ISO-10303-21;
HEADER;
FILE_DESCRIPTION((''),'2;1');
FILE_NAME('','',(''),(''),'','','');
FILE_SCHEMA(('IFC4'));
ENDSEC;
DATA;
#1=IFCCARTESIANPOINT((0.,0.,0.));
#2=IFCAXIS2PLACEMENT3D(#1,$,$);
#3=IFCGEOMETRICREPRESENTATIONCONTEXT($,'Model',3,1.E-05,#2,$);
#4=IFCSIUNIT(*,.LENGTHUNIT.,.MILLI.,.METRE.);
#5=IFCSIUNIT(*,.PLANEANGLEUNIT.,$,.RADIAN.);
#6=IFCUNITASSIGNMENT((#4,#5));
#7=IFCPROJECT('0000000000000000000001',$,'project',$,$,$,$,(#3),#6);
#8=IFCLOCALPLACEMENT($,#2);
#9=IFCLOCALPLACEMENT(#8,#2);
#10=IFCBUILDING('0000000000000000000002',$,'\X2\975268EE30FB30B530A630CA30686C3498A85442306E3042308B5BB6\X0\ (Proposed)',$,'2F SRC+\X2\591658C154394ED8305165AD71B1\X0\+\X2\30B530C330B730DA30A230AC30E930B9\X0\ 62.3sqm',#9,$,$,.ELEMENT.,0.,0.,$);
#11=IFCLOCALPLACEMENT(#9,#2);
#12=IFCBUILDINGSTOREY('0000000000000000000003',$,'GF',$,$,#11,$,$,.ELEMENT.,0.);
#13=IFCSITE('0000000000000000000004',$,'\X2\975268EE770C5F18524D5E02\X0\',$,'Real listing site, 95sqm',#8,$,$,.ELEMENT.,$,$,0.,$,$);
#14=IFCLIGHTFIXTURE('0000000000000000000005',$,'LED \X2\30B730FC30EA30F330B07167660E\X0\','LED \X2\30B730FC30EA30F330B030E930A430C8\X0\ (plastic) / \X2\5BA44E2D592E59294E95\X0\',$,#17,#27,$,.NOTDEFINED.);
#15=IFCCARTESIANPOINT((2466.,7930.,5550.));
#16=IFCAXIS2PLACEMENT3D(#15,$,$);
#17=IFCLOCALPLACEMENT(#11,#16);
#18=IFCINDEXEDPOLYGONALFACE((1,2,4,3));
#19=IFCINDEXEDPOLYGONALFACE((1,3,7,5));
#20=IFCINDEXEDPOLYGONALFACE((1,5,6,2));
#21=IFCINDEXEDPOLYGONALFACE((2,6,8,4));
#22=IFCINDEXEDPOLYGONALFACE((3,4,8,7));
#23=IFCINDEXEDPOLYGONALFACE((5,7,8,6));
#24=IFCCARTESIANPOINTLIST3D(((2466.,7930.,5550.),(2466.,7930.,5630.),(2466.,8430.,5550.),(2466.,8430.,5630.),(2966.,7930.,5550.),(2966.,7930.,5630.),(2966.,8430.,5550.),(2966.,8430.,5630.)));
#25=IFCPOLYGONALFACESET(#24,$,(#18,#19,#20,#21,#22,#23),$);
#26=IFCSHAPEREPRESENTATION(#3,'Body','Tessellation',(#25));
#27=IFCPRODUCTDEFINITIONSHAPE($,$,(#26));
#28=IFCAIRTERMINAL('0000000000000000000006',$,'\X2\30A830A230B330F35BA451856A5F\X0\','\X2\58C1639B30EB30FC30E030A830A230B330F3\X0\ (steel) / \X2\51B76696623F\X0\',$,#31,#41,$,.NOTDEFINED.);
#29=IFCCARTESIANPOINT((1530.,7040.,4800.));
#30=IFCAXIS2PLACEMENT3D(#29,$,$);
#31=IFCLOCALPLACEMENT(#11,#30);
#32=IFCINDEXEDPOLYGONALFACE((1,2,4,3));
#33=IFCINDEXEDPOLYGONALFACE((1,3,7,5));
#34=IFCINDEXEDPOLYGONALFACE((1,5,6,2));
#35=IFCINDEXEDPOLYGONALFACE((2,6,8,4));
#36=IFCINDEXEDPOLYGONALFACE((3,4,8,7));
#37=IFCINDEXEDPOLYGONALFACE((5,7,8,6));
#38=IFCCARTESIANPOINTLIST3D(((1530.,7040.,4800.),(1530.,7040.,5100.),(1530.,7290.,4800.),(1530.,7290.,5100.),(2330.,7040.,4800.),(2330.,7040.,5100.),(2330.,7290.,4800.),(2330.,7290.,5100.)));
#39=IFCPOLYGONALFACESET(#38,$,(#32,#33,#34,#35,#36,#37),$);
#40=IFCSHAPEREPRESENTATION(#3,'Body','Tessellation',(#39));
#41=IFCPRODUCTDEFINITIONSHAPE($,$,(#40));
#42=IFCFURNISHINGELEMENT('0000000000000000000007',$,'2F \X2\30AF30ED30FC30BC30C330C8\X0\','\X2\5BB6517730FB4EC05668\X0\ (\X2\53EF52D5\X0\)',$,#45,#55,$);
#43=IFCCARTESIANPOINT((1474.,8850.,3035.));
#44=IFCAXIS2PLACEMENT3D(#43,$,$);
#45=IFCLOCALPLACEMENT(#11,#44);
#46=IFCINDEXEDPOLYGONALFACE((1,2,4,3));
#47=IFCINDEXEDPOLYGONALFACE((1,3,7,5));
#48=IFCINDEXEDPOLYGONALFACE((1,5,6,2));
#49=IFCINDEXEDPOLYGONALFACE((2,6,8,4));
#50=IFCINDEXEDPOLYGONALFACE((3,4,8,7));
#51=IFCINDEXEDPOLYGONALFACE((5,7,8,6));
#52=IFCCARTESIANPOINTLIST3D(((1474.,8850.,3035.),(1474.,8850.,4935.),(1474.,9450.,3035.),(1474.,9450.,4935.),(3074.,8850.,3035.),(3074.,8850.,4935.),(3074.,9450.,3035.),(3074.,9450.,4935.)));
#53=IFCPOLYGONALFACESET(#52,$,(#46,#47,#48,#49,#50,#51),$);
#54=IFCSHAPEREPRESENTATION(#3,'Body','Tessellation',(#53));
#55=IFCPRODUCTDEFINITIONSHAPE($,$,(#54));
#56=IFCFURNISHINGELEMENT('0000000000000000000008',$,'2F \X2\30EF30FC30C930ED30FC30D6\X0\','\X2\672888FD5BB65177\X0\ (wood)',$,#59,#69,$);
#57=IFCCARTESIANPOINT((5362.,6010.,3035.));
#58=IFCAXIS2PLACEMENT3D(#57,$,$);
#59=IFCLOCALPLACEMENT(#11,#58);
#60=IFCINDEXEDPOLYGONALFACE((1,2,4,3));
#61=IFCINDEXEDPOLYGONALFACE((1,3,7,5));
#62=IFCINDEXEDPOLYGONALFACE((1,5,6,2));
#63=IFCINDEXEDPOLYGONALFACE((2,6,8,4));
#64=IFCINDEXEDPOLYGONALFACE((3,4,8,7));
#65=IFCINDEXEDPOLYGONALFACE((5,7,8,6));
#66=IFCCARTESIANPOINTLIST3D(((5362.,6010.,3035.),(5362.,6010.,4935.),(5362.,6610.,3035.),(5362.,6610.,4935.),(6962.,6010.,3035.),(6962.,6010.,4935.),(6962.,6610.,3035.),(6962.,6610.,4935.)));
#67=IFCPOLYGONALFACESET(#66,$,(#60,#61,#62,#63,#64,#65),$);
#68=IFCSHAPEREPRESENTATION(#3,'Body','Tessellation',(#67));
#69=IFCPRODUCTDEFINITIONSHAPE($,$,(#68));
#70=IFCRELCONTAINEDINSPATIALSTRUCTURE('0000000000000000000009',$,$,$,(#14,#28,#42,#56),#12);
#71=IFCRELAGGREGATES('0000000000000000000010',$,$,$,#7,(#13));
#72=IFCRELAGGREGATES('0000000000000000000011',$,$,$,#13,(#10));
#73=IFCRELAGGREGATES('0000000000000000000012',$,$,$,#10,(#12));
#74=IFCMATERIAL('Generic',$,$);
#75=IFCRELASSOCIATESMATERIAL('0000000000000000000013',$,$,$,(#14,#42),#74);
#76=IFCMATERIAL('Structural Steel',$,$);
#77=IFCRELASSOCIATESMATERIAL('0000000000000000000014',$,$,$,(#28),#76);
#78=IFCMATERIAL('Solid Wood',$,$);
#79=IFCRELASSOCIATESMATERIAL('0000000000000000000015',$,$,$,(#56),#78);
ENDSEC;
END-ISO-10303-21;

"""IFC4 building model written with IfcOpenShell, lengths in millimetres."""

from ifc_helpers import new_model, si_unit, frame, frame_2d, origin, place, context, project, spatial, rectangle, extrude, material, element, save


model = new_model("IFC4")

# Units and contexts
model_context = context("Model", 3, precision=1e-05, world=origin())
ifc_project = project(units=[si_unit("LENGTHUNIT", "METRE", prefix="MILLI"), si_unit("PLANEANGLEUNIT", "RADIAN")], contexts=[model_context])

# Site, building, storey
site_placement = place(None, origin())
site = spatial("IfcSite", under=ifc_project, at=site_placement, Name="青森県弘前市", ObjectType="Real listing site, 95sqm", CompositionType="ELEMENT", RefElevation=0.0)
building_placement = place(site_placement, origin())
building = spatial("IfcBuilding", under=site, at=building_placement, Name="青森・サウナと水風呂のある家 (Proposed)", ObjectType="2F SRC+外壁吹付け断熱+サッシペアガラス 62.3sqm", CompositionType="ELEMENT", ElevationOfRefHeight=0.0, ElevationOfTerrain=0.0)
storey_placement = place(building_placement, origin())
storey = spatial("IfcBuildingStorey", under=building, at=storey_placement, Name="GF", CompositionType="ELEMENT", Elevation=0.0)

# Shared definitions
ifc_material_1 = material(Name="Solid Wood")

# Shared definitions
ifc_material_2 = material(Name="Generic")

# Shared definitions
ifc_material_3 = material(Name="Structural Steel")

# Light fixture
light_fixture_1_placement = place(storey_placement, frame((2466.0, 7930.0, 5550.0)))
element("IfcLightFixture", 1, at=light_fixture_1_placement, inside=storey, material=ifc_material_2, Name="LED シーリング照明", Description="LED シーリングライト (plastic) / 室中央天井", PredefinedType="NOTDEFINED", context=model_context, shape_type="SweptSolid", body=[
    extrude(rectangle(XDim=500.0, YDim=500.0, at=frame_2d((250.0, 250.0))), frame((2466.0, 7930.0, 5550.0)), (0.0, 0.0, 1.0), 80.0),
])

# Air terminal
air_terminal_placement = place(storey_placement, frame((1530.0, 7040.0, 4800.0)))
element("IfcAirTerminal", 2, at=air_terminal_placement, inside=storey, material=ifc_material_3, Name="エアコン室内機", Description="壁掛ルームエアコン (steel) / 冷暖房", PredefinedType="NOTDEFINED", context=model_context, shape_type="SweptSolid", body=[
    extrude(rectangle(XDim=800.0, YDim=250.0, at=frame_2d((400.0, 125.0))), frame((1530.0, 7040.0, 4800.0)), (0.0, 0.0, 1.0), 300.0),
])

# Furnishing elements
furnishing_1_placement = place(storey_placement, frame((1474.0, 8850.0, 3035.0)))
element("IfcFurnishingElement", 3, at=furnishing_1_placement, inside=storey, material=ifc_material_2, Name="2F クローゼット", Description="家具・什器 (可動)", context=model_context, shape_type="SweptSolid", body=[
    extrude(rectangle(XDim=1600.0, YDim=600.0, at=frame_2d((800.0, 300.0))), frame((1474.0, 8850.0, 3035.0)), (0.0, 0.0, 1.0), 1900.0),
])
furnishing_2_placement = place(storey_placement, frame((5362.0, 6010.0, 3035.0)))
element("IfcFurnishingElement", 4, at=furnishing_2_placement, inside=storey, material=ifc_material_1, Name="2F ワードローブ", Description="木製家具 (wood)", context=model_context, shape_type="SweptSolid", body=[
    extrude(rectangle(XDim=1600.0, YDim=600.0, at=frame_2d((800.0, 300.0))), frame((5362.0, 6010.0, 3035.0)), (0.0, 0.0, 1.0), 1900.0),
])

save(model, "model.ifc")
